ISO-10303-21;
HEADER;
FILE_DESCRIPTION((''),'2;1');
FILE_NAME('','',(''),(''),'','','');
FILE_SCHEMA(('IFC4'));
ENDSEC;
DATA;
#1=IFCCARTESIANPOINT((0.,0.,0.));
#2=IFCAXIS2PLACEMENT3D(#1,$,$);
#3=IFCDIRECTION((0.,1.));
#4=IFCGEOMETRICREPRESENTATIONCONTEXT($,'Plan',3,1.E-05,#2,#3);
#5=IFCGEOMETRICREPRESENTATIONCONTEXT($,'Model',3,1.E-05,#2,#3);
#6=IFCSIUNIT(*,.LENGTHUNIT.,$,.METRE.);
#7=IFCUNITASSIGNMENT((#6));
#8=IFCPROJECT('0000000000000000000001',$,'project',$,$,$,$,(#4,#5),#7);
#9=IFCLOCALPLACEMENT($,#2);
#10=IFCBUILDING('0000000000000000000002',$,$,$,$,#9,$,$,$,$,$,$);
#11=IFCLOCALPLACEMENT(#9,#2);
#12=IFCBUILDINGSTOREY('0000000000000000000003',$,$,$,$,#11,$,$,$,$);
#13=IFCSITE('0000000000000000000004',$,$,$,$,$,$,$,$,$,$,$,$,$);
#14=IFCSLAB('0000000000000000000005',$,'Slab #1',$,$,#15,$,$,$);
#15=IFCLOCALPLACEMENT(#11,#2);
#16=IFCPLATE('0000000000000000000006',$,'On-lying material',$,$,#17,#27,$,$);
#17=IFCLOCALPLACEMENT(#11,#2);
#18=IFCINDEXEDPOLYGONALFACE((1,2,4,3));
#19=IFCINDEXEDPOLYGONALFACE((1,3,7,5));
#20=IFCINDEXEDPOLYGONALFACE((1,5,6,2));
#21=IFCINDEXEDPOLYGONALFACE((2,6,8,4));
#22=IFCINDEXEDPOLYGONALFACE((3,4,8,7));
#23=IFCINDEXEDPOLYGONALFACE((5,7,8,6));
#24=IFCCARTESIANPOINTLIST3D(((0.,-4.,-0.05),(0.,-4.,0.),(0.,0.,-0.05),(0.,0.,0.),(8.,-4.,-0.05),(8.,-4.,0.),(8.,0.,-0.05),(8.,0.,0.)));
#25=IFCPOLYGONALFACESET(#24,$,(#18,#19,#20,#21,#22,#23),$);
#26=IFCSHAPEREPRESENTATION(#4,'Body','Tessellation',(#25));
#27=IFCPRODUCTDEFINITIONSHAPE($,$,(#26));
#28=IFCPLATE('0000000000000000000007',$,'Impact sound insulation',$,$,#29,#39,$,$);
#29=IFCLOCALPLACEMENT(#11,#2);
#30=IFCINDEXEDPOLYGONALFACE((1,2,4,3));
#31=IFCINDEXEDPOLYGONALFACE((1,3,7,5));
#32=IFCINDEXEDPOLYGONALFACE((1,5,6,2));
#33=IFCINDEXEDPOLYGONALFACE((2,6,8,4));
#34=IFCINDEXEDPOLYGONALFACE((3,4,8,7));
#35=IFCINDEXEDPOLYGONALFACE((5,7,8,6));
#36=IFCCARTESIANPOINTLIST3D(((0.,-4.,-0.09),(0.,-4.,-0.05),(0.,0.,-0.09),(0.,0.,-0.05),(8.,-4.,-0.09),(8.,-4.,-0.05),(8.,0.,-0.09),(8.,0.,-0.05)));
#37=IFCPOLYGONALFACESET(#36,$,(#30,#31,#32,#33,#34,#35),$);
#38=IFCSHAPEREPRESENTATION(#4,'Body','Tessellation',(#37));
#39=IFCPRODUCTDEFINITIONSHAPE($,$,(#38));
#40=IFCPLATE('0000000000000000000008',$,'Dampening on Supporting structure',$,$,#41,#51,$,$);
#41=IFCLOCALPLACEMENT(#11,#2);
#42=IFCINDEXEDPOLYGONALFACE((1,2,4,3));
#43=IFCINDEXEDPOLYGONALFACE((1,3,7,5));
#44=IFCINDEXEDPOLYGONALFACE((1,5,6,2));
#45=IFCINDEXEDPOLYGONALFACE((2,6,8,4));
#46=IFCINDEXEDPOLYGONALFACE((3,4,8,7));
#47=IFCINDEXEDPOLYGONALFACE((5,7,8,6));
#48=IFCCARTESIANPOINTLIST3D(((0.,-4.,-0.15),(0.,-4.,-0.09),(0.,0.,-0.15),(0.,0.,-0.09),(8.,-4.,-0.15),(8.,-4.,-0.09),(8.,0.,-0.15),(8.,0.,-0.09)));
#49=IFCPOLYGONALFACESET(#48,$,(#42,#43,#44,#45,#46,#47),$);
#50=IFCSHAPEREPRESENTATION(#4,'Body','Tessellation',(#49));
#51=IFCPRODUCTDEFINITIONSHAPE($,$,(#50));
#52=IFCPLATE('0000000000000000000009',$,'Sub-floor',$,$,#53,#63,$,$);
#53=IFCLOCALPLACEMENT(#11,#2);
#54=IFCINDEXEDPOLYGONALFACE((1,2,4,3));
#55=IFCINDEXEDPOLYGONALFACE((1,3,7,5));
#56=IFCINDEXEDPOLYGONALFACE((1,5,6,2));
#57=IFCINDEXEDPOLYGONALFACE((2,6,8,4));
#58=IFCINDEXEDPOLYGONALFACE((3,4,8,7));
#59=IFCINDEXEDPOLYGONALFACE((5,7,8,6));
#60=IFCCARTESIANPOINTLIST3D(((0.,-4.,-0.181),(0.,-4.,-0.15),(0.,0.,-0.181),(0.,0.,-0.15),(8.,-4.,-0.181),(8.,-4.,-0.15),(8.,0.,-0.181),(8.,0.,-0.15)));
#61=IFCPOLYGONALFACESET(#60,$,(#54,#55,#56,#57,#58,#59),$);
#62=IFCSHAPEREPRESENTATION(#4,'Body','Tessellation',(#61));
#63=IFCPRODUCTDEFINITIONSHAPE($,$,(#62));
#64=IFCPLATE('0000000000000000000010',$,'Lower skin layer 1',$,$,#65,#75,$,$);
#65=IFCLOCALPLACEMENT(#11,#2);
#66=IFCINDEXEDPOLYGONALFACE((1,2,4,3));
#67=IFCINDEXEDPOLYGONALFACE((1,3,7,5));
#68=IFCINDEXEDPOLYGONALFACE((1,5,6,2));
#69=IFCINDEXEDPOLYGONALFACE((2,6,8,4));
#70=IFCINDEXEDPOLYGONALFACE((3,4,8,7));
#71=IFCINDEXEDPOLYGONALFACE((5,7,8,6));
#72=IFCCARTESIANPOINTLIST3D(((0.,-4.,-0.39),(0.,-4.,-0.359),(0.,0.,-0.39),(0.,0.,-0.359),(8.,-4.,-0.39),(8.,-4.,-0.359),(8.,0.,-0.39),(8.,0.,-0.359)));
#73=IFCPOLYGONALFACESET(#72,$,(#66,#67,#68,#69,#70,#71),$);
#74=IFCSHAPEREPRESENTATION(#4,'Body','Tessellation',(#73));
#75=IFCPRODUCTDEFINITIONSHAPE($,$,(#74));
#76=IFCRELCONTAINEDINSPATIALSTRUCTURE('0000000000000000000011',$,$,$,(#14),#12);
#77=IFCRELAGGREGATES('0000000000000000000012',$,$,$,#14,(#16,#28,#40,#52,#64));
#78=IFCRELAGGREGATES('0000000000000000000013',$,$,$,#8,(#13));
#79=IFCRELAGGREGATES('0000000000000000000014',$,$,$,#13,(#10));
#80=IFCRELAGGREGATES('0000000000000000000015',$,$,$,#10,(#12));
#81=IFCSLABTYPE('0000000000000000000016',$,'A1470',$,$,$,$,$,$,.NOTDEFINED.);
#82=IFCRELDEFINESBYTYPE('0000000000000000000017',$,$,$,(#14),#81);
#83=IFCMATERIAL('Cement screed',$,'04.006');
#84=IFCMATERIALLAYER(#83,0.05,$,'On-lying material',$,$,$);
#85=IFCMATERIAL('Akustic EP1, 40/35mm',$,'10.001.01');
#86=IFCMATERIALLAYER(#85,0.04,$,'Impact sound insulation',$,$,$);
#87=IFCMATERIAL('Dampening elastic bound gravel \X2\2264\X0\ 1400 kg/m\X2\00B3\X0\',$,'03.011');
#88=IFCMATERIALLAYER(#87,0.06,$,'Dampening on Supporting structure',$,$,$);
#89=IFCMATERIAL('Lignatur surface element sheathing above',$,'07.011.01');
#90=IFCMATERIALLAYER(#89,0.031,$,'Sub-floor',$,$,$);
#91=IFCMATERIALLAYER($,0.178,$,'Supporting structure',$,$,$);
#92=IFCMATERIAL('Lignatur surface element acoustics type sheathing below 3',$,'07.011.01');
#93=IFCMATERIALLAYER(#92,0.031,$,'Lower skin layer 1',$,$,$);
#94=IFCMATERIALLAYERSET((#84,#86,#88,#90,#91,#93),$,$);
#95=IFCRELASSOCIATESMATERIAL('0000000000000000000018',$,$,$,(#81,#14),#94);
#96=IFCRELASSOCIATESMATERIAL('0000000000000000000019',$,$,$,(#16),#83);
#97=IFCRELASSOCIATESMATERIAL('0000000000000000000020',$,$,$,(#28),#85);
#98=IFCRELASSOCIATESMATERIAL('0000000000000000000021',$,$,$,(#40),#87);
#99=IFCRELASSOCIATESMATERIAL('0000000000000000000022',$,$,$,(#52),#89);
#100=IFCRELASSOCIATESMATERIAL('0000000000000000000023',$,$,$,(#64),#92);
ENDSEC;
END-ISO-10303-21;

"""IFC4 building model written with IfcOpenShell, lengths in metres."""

from ifc_helpers import new_model, si_unit, direction, frame, frame_2d, origin, origin_with_axes, place, context, project, spatial, rectangle, extrude, material, layer, layer_set, type_object, element, aggregate, save


model = new_model("IFC4")

# Units and contexts
plan_context = context("Plan", 3, precision=1e-05, world=origin(), true_north=direction((0.0, 1.0)))
model_context = context("Model", 3, precision=1e-05, world=origin(), true_north=direction((0.0, 1.0)))
ifc_project = project(units=[si_unit("LENGTHUNIT", "METRE")], contexts=[plan_context, model_context])

# Site, building, storey
site = spatial("IfcSite", under=ifc_project)
building_placement = place(None, origin())
building = spatial("IfcBuilding", under=site, at=building_placement)
storey_placement = place(building_placement, origin())
storey = spatial("IfcBuildingStorey", under=building, at=storey_placement)

# Slab, plates
ifc_material_1 = material(Name="Cement screed", Category="04.006")
ifc_layer_1 = layer(ifc_material_1, 0.05, Name="On-lying material")
ifc_material_2 = material(Name="Akustic EP1, 40/35mm", Category="10.001.01")
ifc_layer_2 = layer(ifc_material_2, 0.04, Name="Impact sound insulation")
ifc_material_3 = material(Name="Dampening elastic bound gravel ≤ 1400 kg/m³", Category="03.011")
ifc_layer_3 = layer(ifc_material_3, 0.06, Name="Dampening on Supporting structure")
ifc_material_4 = material(Name="Lignatur surface element sheathing above", Category="07.011.01")
ifc_layer_4 = layer(ifc_material_4, 0.031, Name="Sub-floor")
ifc_layer_5 = layer(None, 0.178, Name="Supporting structure")
ifc_material_5 = material(Name="Lignatur surface element acoustics type sheathing below 3", Category="07.011.01")
ifc_layer_6 = layer(ifc_material_5, 0.031, Name="Lower skin layer 1")
ifc_layer_set = layer_set([ifc_layer_1, ifc_layer_2, ifc_layer_3, ifc_layer_4, ifc_layer_5, ifc_layer_6])
slab_type = type_object("IfcSlabType", Name="A1470", PredefinedType="NOTDEFINED", material=ifc_layer_set)
slab_placement = place(None, frame((0.0, 0.0, 0.0), z_axis=(0.0, 0.0, -1.0), x_axis=(1.0, 0.0, 0.0)))
slab = element("IfcSlab", 1, at=slab_placement, inside=storey, type_object=slab_type, material=ifc_layer_set, Name="Slab #1")
plate_1_placement = place(slab_placement, origin())
plate_1 = element("IfcPlate", 2, at=plate_1_placement, material=ifc_material_1, Name="On-lying material", context=plan_context, shape_type="SweptSolid", body=[
    extrude(rectangle(XDim=8.0, YDim=4.0, at=frame_2d((4.0, 2.0), x_axis=(1.0, 0.0))), origin_with_axes(), (0.0, 0.0, 1.0), 0.05),
])
plate_2_placement = place(slab_placement, origin())
plate_2 = element("IfcPlate", 3, at=plate_2_placement, material=ifc_material_2, Name="Impact sound insulation", context=plan_context, shape_type="SweptSolid", body=[
    extrude(rectangle(XDim=8.0, YDim=4.0, at=frame_2d((4.0, 2.0), x_axis=(1.0, 0.0))), frame((0.0, 0.0, 0.05), z_axis=(0.0, 0.0, 1.0), x_axis=(1.0, 0.0, 0.0)), (0.0, 0.0, 1.0), 0.04),
])
plate_3_placement = place(slab_placement, origin())
plate_3 = element("IfcPlate", 4, at=plate_3_placement, material=ifc_material_3, Name="Dampening on Supporting structure", context=plan_context, shape_type="SweptSolid", body=[
    extrude(rectangle(XDim=8.0, YDim=4.0, at=frame_2d((4.0, 2.0), x_axis=(1.0, 0.0))), frame((0.0, 0.0, 0.09), z_axis=(0.0, 0.0, 1.0), x_axis=(1.0, 0.0, 0.0)), (0.0, 0.0, 1.0), 0.06),
])
plate_4_placement = place(slab_placement, origin())
plate_4 = element("IfcPlate", 5, at=plate_4_placement, material=ifc_material_4, Name="Sub-floor", context=plan_context, shape_type="SweptSolid", body=[
    extrude(rectangle(XDim=8.0, YDim=4.0, at=frame_2d((4.0, 2.0), x_axis=(1.0, 0.0))), frame((0.0, 0.0, 0.15), z_axis=(0.0, 0.0, 1.0), x_axis=(1.0, 0.0, 0.0)), (0.0, 0.0, 1.0), 0.031),
])
plate_5_placement = place(slab_placement, origin())
plate_5 = element("IfcPlate", 6, at=plate_5_placement, material=ifc_material_5, Name="Lower skin layer 1", context=plan_context, shape_type="SweptSolid", body=[
    extrude(rectangle(XDim=8.0, YDim=4.0, at=frame_2d((4.0, 2.0), x_axis=(1.0, 0.0))), frame((0.0, 0.0, 0.359), z_axis=(0.0, 0.0, 1.0), x_axis=(1.0, 0.0, 0.0)), (0.0, 0.0, 1.0), 0.031),
])
aggregate(slab, [plate_1, plate_2, plate_3, plate_4, plate_5])

save(model, "model.ifc")
